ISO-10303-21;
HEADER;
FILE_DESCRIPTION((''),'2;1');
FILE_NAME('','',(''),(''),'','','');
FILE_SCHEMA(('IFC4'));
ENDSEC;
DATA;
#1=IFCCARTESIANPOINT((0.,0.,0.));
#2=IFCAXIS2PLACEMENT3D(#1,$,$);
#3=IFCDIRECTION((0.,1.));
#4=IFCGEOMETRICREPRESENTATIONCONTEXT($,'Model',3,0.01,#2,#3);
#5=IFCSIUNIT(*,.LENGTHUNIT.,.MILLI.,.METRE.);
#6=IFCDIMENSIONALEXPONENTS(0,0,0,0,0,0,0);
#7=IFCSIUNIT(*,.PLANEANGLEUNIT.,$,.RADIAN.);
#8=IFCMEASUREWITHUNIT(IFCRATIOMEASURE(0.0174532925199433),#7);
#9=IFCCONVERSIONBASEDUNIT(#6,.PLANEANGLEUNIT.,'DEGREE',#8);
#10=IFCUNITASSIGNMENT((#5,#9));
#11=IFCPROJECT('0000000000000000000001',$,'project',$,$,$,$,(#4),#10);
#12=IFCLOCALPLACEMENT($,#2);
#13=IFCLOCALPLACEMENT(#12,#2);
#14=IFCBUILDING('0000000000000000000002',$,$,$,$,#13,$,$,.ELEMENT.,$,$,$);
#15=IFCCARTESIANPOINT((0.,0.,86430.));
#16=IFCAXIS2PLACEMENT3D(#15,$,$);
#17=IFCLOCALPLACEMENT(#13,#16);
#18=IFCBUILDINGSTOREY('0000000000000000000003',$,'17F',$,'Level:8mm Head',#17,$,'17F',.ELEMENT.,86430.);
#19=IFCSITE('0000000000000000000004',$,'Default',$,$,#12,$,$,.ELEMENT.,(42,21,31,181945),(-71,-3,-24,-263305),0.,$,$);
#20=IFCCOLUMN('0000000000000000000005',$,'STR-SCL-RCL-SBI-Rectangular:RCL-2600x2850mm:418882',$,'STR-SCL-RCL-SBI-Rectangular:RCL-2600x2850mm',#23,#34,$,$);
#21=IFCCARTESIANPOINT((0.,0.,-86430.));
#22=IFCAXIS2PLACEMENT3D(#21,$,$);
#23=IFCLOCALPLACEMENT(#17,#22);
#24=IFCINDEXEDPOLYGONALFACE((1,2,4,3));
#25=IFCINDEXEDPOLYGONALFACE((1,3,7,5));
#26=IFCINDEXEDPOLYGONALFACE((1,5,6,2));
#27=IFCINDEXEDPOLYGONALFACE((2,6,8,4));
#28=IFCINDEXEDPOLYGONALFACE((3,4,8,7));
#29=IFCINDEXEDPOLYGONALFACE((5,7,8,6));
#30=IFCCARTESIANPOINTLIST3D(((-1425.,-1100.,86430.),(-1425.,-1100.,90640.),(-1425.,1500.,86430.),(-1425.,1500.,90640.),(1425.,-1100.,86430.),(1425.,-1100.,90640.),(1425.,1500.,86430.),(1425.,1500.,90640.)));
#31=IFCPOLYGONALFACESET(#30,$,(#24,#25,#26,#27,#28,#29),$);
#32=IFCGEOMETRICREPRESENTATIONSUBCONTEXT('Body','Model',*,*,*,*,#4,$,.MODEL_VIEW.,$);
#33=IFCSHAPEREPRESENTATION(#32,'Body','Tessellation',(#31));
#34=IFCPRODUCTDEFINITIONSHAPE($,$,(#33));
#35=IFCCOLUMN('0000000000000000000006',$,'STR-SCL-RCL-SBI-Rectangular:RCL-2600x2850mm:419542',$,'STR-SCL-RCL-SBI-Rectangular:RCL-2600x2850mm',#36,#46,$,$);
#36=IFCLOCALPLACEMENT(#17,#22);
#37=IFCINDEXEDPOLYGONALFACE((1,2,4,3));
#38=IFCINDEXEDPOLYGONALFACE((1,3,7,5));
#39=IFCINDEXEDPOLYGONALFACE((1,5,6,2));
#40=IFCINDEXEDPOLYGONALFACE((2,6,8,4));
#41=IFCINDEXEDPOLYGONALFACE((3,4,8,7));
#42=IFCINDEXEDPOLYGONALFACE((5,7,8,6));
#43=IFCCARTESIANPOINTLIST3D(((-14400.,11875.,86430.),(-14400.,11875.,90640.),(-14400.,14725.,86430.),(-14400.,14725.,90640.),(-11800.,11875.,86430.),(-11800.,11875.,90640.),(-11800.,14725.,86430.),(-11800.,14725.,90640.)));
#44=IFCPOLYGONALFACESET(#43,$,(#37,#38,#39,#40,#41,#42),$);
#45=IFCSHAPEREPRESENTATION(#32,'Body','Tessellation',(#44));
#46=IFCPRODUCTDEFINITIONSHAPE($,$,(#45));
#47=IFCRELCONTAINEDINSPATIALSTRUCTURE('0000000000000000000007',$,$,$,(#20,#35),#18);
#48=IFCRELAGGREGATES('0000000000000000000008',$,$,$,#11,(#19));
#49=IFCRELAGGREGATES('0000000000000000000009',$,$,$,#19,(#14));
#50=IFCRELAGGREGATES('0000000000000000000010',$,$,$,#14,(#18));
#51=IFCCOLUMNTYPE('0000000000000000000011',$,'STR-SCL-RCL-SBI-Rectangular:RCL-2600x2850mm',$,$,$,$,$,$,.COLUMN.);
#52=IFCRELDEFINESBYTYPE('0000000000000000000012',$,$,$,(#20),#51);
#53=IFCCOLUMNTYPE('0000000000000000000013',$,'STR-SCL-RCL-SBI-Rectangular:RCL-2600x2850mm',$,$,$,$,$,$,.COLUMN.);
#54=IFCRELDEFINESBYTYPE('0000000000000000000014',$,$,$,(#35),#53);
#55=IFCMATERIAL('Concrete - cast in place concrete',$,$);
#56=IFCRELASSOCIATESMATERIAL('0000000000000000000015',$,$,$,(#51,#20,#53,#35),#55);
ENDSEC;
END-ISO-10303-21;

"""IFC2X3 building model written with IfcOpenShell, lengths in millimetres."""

from ifc_helpers import new_model, entity, si_unit, converted_unit, direction, frame, frame_2d, origin, origin_2d_with_axis, place, context, subcontext, project, spatial, rectangle, extrude, source, transform, mapped, material, type_object, type_shapes, element, save


model = new_model("IFC2X3")

# Units and contexts
model_context = context("Model", 3, precision=0.01, world=origin(), true_north=direction((0.0, 1.0)))
body_context = subcontext(model_context, "Body", "Model", "MODEL_VIEW")
ifc_project = project(units=[si_unit("LENGTHUNIT", "METRE", prefix="MILLI"), converted_unit("PLANEANGLEUNIT", "DEGREE", entity("IfcRatioMeasure", 0.0174532925199433), si_unit("PLANEANGLEUNIT", "RADIAN"), dimensions=[0, 0, 0, 0, 0, 0, 0])], contexts=[model_context])

# Site, building, storey
site_placement = place(None, origin())
site = spatial("IfcSite", under=ifc_project, at=site_placement, Name="Default", CompositionType="ELEMENT", RefLatitude=(42, 21, 31, 181945), RefLongitude=(-71, -3, -24, -263305), RefElevation=0.0)
building_placement = place(site_placement, origin())
building = spatial("IfcBuilding", under=site, at=building_placement, CompositionType="ELEMENT")
storey_placement = place(building_placement, frame((0.0, 0.0, 86430.0)))
storey = spatial("IfcBuildingStorey", under=building, at=storey_placement, Name="17F", ObjectType="Level:8mm Head", LongName="17F", CompositionType="ELEMENT", Elevation=86430.0)

# Columns
ifc_material_1 = material(Name="Concrete - cast in place concrete")
column_type_1 = type_object("IfcColumnType", Name="STR-SCL-RCL-SBI-Rectangular:RCL-2600x2850mm", PredefinedType="COLUMN", material=ifc_material_1)
shared_shape_1 = source(origin(), body_context, "Body", "SweptSolid", [
    extrude(rectangle(XDim=2600.0, YDim=2850.0, at=origin_2d_with_axis()), frame((0.0, 200.0, 86430.0), z_axis=(0.0, 0.0, 1.0), x_axis=(0.0, -1.0, 0.0)), (0.0, 0.0, 1.0), 4210.0),
])
type_shapes(column_type_1, [shared_shape_1])
column_1_placement = place(storey_placement, frame((0.0, 0.0, -86430.0)))
element("IfcColumn", 1, at=column_1_placement, inside=storey, type_object=column_type_1, material=ifc_material_1, Name="STR-SCL-RCL-SBI-Rectangular:RCL-2600x2850mm:418882", ObjectType="STR-SCL-RCL-SBI-Rectangular:RCL-2600x2850mm", context=body_context, shape_type="MappedRepresentation", body=[
    mapped(shared_shape_1, transform((0.0, 0.0, 0.0), scale=1.0)),
])
column_type_2 = type_object("IfcColumnType", Name="STR-SCL-RCL-SBI-Rectangular:RCL-2600x2850mm", PredefinedType="COLUMN", material=ifc_material_1)
shared_shape_2 = source(origin(), body_context, "Body", "SweptSolid", [
    extrude(rectangle(XDim=2850.0, YDim=2600.0, at=frame_2d((0.0, 0.0), x_axis=(1.0, 0.0))), frame((-13100.0, 13300.0, 86430.0), z_axis=(0.0, 0.0, 1.0), x_axis=(0.0, -1.0, 0.0)), (0.0, 0.0, 1.0), 4210.0),
])
type_shapes(column_type_2, [shared_shape_2])
column_2_placement = place(storey_placement, frame((0.0, 0.0, -86430.0)))
element("IfcColumn", 2, at=column_2_placement, inside=storey, type_object=column_type_2, material=ifc_material_1, Name="STR-SCL-RCL-SBI-Rectangular:RCL-2600x2850mm:419542", ObjectType="STR-SCL-RCL-SBI-Rectangular:RCL-2600x2850mm", context=body_context, shape_type="MappedRepresentation", body=[
    mapped(shared_shape_2, transform((0.0, 0.0, 0.0), scale=1.0)),
])

save(model, "model.ifc")
